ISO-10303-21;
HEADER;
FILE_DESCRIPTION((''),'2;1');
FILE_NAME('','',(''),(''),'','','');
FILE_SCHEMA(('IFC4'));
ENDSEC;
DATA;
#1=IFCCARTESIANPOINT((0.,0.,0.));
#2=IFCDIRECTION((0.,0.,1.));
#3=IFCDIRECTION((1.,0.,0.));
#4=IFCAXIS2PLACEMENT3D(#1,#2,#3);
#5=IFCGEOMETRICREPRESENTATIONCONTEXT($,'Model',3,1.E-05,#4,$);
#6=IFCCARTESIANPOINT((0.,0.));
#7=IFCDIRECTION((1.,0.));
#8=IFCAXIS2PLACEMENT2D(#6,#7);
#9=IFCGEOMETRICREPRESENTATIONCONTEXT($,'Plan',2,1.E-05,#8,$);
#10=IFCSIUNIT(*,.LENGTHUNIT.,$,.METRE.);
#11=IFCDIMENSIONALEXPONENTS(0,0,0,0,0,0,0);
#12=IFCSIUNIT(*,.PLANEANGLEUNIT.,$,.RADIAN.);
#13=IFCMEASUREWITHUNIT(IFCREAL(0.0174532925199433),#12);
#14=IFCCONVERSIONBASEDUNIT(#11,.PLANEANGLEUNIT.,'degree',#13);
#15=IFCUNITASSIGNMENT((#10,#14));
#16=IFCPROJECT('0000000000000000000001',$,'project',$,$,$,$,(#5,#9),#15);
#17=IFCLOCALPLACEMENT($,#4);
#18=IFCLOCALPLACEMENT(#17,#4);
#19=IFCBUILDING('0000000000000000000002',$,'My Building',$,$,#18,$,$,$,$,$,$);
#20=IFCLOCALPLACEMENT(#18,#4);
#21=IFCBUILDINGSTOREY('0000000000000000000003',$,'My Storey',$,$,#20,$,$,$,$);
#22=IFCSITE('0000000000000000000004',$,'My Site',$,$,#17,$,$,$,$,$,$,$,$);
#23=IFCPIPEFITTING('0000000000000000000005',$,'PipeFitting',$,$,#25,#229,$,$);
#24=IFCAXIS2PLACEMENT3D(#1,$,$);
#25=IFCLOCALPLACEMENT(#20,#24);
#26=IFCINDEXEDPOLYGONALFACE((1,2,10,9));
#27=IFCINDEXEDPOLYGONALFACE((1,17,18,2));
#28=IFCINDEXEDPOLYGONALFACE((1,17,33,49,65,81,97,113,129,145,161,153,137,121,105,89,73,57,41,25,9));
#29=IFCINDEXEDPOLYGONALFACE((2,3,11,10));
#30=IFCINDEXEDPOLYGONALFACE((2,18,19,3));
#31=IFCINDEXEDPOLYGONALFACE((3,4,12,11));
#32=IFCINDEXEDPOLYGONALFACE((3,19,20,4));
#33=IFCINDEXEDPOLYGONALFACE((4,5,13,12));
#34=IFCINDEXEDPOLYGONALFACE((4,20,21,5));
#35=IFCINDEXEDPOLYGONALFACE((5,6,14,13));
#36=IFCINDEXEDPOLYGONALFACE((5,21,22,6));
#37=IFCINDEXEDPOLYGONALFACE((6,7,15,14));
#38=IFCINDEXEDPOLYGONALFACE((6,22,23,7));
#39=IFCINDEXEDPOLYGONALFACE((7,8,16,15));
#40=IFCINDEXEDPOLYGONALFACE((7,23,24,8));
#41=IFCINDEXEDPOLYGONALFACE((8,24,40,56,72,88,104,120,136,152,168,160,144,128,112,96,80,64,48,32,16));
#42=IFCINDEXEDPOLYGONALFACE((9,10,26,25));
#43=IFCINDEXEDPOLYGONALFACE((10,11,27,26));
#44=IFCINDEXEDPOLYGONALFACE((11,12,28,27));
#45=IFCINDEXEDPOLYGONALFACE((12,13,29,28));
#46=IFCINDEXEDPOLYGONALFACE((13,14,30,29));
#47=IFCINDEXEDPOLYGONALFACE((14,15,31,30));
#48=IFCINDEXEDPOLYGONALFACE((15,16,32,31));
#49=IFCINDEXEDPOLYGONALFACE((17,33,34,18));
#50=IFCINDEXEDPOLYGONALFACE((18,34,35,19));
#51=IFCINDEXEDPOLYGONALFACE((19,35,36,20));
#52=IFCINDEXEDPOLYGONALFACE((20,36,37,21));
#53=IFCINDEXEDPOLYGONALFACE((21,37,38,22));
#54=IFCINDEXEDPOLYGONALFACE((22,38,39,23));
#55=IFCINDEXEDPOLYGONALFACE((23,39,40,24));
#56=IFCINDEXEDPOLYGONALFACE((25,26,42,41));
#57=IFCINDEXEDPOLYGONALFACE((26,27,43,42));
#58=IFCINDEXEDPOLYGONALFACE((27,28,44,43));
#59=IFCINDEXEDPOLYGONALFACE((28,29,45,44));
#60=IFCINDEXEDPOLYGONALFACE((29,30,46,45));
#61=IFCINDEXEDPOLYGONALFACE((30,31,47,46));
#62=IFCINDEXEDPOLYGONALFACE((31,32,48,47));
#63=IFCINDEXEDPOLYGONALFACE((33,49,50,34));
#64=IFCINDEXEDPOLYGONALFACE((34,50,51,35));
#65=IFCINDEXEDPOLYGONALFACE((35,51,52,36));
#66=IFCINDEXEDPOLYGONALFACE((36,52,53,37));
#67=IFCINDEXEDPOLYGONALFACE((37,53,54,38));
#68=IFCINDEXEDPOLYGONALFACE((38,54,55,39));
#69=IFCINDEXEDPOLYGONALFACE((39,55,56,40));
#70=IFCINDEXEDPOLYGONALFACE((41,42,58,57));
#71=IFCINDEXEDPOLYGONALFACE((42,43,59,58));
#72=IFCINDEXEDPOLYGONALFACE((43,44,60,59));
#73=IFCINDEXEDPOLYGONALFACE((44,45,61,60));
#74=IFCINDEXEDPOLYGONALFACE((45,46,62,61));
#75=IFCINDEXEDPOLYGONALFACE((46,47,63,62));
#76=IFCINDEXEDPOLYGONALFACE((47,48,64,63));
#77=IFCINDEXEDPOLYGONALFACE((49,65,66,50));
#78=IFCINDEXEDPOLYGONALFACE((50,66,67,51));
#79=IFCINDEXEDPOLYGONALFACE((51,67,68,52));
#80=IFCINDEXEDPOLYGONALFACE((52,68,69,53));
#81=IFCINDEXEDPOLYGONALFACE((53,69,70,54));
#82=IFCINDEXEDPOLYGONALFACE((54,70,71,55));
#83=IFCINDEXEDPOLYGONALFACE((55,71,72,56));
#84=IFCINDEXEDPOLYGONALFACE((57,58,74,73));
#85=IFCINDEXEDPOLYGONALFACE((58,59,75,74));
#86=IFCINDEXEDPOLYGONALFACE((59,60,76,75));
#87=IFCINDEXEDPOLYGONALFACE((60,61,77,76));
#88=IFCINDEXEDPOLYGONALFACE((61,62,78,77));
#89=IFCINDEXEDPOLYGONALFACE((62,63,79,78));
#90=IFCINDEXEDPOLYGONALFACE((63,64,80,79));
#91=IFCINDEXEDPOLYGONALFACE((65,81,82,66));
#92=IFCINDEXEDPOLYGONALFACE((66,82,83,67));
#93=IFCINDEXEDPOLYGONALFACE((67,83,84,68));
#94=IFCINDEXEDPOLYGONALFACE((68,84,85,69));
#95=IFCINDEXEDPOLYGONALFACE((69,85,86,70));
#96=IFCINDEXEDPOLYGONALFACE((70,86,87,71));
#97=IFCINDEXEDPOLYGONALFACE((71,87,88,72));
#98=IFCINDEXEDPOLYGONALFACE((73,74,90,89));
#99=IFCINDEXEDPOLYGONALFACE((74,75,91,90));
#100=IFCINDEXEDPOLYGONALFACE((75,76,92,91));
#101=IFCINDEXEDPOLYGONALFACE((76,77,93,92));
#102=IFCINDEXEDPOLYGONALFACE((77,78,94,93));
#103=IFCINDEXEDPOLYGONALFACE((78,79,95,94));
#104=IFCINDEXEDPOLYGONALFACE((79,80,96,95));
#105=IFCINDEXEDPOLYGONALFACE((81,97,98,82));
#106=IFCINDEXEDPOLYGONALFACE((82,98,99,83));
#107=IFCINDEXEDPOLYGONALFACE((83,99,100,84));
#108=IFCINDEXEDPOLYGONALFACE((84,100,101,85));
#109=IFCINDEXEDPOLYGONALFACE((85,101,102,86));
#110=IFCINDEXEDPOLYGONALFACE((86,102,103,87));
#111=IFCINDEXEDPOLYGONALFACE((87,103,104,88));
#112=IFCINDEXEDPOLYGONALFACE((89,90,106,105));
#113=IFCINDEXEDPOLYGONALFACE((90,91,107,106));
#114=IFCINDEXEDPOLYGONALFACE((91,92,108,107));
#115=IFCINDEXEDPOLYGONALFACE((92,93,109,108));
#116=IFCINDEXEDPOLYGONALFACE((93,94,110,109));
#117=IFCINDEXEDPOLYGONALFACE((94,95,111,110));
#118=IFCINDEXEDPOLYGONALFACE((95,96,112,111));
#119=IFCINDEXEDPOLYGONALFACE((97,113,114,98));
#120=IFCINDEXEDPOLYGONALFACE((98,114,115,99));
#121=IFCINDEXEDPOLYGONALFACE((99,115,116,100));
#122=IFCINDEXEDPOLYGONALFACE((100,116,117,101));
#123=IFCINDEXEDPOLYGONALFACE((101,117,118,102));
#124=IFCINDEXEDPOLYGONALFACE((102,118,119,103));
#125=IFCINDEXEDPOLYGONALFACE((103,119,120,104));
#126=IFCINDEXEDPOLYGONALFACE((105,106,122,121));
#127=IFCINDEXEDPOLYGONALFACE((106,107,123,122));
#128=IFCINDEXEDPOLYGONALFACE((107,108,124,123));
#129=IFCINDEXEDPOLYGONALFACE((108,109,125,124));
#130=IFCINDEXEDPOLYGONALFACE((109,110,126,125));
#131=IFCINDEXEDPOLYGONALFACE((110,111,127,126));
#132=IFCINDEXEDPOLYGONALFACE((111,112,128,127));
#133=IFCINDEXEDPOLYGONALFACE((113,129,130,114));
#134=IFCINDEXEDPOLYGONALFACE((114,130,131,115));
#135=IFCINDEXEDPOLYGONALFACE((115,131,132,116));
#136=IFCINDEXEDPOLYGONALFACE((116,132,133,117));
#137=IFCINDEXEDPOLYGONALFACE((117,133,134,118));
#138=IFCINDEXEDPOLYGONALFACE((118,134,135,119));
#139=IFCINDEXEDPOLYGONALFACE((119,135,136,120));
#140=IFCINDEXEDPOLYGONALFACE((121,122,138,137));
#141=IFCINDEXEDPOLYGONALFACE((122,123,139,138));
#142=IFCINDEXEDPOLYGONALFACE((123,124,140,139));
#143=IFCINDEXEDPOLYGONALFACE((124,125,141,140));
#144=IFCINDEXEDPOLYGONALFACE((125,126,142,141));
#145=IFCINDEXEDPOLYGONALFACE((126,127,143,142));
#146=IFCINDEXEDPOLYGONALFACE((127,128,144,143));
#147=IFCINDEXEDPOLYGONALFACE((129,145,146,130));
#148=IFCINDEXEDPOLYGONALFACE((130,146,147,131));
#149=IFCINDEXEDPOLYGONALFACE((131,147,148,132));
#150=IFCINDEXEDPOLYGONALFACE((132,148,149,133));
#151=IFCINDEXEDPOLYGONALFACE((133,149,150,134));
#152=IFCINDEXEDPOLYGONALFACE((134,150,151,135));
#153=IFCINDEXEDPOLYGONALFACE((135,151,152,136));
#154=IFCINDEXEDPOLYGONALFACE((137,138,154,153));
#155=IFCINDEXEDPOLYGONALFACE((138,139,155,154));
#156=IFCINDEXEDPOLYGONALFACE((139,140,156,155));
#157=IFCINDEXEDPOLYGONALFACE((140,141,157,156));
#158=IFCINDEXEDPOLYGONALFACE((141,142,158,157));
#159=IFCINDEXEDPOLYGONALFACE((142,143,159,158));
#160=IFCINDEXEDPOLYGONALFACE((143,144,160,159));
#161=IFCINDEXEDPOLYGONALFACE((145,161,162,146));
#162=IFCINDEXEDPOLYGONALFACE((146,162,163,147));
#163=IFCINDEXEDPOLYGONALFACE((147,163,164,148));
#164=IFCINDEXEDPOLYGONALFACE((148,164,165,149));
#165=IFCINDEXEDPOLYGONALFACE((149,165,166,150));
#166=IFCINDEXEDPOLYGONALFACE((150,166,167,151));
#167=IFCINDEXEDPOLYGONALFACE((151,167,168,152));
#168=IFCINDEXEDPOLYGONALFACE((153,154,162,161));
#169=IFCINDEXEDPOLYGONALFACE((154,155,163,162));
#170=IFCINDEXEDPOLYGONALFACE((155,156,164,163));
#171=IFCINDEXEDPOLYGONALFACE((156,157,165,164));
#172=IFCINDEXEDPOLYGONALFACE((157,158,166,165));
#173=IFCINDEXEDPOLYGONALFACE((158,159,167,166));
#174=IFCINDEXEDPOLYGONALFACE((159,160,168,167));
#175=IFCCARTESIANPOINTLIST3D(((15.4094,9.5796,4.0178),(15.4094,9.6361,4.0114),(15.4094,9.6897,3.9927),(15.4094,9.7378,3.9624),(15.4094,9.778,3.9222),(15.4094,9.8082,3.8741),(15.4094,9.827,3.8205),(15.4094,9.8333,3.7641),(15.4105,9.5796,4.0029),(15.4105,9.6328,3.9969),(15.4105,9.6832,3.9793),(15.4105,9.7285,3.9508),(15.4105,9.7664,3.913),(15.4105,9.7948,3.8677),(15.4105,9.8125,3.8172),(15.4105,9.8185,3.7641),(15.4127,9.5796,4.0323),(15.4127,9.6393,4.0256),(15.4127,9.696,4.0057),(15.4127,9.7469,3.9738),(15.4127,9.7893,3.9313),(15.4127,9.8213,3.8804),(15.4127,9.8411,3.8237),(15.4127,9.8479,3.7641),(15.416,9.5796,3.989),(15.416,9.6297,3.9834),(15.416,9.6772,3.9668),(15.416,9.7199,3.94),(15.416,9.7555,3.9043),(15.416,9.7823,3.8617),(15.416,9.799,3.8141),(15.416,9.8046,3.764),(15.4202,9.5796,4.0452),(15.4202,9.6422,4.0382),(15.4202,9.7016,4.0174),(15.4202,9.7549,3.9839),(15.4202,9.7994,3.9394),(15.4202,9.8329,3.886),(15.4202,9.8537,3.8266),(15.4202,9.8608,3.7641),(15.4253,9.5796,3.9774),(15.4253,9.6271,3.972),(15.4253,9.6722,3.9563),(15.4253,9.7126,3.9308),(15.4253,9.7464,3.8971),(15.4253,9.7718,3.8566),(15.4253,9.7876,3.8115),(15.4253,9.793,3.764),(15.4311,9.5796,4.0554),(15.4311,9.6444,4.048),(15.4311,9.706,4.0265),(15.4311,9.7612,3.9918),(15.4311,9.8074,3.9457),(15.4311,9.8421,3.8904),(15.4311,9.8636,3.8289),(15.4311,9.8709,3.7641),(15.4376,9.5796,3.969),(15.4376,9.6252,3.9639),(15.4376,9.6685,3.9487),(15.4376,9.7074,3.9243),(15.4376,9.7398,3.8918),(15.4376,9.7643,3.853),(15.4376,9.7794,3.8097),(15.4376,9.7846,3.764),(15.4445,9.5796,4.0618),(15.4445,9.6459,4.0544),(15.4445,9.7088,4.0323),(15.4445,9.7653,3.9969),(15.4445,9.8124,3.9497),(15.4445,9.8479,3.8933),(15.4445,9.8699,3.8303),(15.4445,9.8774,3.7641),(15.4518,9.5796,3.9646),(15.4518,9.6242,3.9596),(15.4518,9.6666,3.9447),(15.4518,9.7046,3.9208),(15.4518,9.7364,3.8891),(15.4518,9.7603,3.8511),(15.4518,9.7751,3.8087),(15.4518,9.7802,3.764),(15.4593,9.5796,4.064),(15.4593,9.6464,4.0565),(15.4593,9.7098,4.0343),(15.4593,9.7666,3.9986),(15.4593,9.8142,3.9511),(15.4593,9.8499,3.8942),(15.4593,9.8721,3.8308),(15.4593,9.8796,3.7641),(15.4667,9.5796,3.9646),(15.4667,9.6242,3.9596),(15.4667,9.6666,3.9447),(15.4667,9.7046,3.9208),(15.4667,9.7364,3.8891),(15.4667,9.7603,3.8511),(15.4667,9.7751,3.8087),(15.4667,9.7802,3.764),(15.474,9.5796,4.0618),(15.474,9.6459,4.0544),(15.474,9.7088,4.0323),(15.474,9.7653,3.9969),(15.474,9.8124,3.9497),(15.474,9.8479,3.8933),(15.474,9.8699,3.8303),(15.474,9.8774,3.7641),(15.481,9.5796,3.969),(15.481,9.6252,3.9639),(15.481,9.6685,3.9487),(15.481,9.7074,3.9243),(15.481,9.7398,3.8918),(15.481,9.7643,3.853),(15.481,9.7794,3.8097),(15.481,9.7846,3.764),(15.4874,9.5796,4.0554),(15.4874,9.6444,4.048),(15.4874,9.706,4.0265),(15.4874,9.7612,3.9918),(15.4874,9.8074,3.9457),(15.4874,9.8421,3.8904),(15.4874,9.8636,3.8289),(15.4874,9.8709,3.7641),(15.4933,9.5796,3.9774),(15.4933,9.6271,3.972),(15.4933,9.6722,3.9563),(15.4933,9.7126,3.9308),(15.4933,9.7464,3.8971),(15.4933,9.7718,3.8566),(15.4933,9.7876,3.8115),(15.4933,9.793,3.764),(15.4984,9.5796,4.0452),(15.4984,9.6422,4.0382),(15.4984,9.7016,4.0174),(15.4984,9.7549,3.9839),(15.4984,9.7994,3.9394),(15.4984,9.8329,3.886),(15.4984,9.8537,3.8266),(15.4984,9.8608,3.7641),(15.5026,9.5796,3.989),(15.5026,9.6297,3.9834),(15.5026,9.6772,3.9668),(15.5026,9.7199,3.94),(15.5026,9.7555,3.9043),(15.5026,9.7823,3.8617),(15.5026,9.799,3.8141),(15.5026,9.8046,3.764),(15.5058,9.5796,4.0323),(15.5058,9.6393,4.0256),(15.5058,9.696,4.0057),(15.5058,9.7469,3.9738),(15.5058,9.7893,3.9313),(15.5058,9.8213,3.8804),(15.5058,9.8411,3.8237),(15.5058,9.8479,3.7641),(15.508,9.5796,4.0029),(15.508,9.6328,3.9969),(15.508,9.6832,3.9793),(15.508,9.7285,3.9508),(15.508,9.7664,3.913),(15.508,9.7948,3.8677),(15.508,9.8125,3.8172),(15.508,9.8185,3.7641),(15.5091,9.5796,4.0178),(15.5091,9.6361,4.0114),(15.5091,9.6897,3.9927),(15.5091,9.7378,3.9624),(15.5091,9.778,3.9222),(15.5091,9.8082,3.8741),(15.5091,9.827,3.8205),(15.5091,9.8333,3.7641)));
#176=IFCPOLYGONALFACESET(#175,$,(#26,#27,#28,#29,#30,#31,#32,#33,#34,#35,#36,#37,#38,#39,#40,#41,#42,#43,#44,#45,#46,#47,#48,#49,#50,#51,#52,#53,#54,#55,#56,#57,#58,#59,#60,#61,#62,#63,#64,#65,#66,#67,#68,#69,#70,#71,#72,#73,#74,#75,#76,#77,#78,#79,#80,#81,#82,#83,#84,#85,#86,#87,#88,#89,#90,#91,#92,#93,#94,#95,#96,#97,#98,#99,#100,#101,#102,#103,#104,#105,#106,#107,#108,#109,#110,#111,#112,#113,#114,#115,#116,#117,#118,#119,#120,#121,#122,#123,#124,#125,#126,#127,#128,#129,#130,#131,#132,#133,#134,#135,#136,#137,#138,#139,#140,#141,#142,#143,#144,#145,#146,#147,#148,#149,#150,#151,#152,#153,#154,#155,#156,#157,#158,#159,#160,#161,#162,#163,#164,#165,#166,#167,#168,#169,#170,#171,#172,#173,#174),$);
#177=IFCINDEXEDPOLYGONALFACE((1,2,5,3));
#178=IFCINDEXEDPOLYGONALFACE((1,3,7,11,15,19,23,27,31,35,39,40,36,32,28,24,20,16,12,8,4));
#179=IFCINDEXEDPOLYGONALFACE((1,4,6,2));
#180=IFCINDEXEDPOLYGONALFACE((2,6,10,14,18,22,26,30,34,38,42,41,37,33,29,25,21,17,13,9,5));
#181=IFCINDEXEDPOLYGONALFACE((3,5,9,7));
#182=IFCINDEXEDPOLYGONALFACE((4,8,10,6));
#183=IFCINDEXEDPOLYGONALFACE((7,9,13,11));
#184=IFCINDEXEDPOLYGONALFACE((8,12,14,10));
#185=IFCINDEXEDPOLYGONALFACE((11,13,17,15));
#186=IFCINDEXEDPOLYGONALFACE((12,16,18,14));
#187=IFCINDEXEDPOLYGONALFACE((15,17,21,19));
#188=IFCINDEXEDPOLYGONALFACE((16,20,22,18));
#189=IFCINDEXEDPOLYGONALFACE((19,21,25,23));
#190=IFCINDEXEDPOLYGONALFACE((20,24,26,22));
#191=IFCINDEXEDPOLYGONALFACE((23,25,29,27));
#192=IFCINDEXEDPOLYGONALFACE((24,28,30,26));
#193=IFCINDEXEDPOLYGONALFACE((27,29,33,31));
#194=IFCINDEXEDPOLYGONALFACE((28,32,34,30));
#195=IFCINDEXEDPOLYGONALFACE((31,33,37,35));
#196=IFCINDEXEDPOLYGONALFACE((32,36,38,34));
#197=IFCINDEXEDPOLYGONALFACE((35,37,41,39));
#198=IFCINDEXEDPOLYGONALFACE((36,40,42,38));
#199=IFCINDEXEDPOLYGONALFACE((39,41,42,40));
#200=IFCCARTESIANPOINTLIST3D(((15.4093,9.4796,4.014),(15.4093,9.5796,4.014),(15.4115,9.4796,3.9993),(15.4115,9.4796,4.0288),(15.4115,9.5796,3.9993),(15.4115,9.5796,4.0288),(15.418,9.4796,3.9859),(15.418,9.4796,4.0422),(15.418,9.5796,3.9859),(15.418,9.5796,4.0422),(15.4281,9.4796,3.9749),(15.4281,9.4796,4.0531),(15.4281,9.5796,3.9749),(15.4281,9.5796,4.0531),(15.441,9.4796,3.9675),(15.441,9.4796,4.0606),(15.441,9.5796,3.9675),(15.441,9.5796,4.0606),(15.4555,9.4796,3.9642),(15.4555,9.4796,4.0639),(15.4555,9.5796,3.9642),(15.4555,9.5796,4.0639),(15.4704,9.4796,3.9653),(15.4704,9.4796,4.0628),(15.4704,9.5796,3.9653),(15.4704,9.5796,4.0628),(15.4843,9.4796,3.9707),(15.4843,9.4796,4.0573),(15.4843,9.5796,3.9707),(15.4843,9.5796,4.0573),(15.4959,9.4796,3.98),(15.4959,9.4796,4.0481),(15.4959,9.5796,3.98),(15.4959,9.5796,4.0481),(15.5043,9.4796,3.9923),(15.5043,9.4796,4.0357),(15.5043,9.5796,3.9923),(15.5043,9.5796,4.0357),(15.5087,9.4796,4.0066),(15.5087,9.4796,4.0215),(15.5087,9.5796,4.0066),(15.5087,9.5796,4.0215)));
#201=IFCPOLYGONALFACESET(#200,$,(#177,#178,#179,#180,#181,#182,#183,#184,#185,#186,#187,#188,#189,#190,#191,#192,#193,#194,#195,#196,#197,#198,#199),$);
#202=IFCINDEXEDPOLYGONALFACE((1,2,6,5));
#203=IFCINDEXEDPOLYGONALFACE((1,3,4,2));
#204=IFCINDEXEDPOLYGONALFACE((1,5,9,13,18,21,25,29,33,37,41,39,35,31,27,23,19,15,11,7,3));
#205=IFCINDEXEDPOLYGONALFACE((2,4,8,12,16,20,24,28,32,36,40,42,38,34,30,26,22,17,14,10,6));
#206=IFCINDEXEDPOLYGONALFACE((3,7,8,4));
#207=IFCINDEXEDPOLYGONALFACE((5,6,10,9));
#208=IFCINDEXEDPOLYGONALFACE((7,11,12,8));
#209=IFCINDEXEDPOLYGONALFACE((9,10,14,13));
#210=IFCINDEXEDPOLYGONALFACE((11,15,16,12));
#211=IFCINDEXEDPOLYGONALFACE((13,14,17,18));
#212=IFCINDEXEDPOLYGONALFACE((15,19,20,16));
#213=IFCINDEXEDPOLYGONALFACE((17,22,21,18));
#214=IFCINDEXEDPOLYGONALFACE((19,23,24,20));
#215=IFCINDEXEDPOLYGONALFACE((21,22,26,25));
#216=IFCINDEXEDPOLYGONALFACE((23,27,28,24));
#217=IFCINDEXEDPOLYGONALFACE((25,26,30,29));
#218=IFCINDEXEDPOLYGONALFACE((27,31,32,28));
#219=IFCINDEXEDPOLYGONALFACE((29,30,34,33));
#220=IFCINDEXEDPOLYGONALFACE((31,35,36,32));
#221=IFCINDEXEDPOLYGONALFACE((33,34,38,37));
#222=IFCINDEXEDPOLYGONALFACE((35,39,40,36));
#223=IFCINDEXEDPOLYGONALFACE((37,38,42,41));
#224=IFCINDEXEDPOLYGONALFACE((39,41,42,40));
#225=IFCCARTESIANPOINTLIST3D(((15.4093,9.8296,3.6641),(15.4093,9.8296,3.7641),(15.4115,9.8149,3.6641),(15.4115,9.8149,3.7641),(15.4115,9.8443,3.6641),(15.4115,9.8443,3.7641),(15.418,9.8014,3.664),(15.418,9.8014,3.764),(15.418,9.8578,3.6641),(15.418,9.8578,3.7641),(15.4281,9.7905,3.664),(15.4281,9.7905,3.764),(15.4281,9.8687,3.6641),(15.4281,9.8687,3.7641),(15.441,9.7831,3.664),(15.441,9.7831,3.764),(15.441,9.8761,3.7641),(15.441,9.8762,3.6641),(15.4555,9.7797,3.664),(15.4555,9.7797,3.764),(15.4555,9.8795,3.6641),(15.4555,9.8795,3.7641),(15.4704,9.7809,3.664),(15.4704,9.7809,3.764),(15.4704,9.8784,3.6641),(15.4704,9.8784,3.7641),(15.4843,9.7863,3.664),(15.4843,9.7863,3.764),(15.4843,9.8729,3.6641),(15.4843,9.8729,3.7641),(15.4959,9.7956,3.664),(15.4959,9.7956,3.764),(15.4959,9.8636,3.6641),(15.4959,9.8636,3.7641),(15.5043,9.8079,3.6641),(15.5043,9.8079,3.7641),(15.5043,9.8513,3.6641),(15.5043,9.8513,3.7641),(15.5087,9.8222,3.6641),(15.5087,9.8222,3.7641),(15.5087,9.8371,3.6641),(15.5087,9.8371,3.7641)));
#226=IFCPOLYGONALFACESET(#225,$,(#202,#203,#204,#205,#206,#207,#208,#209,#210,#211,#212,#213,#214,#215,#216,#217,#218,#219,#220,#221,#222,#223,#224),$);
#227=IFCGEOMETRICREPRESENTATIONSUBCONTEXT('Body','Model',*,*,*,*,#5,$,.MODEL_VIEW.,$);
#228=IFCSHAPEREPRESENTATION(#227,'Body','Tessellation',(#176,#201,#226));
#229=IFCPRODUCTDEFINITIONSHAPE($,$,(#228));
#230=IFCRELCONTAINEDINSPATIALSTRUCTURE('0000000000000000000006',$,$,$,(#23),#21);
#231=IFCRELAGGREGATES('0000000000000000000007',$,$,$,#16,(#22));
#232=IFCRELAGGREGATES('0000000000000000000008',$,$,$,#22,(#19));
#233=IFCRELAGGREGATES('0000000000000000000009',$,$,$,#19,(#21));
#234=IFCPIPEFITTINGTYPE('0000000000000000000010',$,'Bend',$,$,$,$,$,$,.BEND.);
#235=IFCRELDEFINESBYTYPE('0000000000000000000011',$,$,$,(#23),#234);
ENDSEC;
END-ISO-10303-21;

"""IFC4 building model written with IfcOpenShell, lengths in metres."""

from ifc_helpers import new_model, entity, si_unit, converted_unit, frame, origin_with_axes, origin_2d_with_axis, place, context, subcontext, project, spatial, circle, extrude, source, transform, mapped, type_object, type_shapes, element, save


model = new_model("IFC4")

# Units and contexts
model_context = context("Model", 3, precision=1e-05, world=origin_with_axes())
plan_context = context("Plan", 2, precision=1e-05, world=origin_2d_with_axis())
body_context_1 = subcontext(model_context, "Body", "Model", "MODEL_VIEW")
ifc_project = project(units=[si_unit("LENGTHUNIT", "METRE"), converted_unit("PLANEANGLEUNIT", "degree", entity("IfcReal", 0.0174532925199433), si_unit("PLANEANGLEUNIT", "RADIAN"), dimensions=[0, 0, 0, 0, 0, 0, 0])], contexts=[model_context, plan_context])

# Site, building, storey
site_placement = place(None, origin_with_axes())
site = spatial("IfcSite", under=ifc_project, at=site_placement, Name="My Site")
building_placement = place(site_placement, origin_with_axes())
building = spatial("IfcBuilding", under=site, at=building_placement, Name="My Building")
storey_placement = place(building_placement, origin_with_axes())
storey = spatial("IfcBuildingStorey", under=building, at=storey_placement, Name="My Storey")

# Pipe fitting
pipe_fitting_type_1 = type_object("IfcPipeFittingType", Name="Bend", PredefinedType="BEND")
shared_shape_1 = source(origin_with_axes(), body_context_1, "Body", "SolidModel", [
    entity("IfcSweptDiskSolid", entity("IfcIndexedPolyCurve", entity("IfcCartesianPointList3D", [[0.0, 0.0, 0.1], [0.0, -0.0732, 0.2768], [0.0, -0.25, 0.35]]), [entity("IfcArcIndex", [1, 2, 3])]), 0.05),
    extrude(circle(Radius=0.05), origin_with_axes(), (0.0, 0.0, 1.0), 0.1),
    extrude(circle(Radius=0.05), frame((0.0, -0.25, 0.35), z_axis=(0.0, -1.0, 0.000038), x_axis=(1.0, 0.0, 0.0)), (0.0, 0.0, 1.0), 0.1),
])
type_shapes(pipe_fitting_type_1, [shared_shape_1])
for number, where, z_axis, x_axis, name in (
    (1, (15.4593, 9.4796, 4.014), (0.0, 1.0, 0.0), (-1.0, 0.0, 0.0), "PipeFitting"),
):
    element("IfcPipeFitting", number, at=place(storey_placement, frame(where, z_axis=z_axis, x_axis=x_axis)), inside=storey, type_object=pipe_fitting_type_1, Name=name, context=body_context_1, shape_type="MappedRepresentation", body=[
        mapped(shared_shape_1, transform((0.0, 0.0, 0.0), x_axis=(1.0, 0.0, 0.0), y_axis=(0.0, 1.0, 0.0), z_axis=(0.0, 0.0, 1.0), scale=1.0)),
    ])

save(model, "model.ifc")
